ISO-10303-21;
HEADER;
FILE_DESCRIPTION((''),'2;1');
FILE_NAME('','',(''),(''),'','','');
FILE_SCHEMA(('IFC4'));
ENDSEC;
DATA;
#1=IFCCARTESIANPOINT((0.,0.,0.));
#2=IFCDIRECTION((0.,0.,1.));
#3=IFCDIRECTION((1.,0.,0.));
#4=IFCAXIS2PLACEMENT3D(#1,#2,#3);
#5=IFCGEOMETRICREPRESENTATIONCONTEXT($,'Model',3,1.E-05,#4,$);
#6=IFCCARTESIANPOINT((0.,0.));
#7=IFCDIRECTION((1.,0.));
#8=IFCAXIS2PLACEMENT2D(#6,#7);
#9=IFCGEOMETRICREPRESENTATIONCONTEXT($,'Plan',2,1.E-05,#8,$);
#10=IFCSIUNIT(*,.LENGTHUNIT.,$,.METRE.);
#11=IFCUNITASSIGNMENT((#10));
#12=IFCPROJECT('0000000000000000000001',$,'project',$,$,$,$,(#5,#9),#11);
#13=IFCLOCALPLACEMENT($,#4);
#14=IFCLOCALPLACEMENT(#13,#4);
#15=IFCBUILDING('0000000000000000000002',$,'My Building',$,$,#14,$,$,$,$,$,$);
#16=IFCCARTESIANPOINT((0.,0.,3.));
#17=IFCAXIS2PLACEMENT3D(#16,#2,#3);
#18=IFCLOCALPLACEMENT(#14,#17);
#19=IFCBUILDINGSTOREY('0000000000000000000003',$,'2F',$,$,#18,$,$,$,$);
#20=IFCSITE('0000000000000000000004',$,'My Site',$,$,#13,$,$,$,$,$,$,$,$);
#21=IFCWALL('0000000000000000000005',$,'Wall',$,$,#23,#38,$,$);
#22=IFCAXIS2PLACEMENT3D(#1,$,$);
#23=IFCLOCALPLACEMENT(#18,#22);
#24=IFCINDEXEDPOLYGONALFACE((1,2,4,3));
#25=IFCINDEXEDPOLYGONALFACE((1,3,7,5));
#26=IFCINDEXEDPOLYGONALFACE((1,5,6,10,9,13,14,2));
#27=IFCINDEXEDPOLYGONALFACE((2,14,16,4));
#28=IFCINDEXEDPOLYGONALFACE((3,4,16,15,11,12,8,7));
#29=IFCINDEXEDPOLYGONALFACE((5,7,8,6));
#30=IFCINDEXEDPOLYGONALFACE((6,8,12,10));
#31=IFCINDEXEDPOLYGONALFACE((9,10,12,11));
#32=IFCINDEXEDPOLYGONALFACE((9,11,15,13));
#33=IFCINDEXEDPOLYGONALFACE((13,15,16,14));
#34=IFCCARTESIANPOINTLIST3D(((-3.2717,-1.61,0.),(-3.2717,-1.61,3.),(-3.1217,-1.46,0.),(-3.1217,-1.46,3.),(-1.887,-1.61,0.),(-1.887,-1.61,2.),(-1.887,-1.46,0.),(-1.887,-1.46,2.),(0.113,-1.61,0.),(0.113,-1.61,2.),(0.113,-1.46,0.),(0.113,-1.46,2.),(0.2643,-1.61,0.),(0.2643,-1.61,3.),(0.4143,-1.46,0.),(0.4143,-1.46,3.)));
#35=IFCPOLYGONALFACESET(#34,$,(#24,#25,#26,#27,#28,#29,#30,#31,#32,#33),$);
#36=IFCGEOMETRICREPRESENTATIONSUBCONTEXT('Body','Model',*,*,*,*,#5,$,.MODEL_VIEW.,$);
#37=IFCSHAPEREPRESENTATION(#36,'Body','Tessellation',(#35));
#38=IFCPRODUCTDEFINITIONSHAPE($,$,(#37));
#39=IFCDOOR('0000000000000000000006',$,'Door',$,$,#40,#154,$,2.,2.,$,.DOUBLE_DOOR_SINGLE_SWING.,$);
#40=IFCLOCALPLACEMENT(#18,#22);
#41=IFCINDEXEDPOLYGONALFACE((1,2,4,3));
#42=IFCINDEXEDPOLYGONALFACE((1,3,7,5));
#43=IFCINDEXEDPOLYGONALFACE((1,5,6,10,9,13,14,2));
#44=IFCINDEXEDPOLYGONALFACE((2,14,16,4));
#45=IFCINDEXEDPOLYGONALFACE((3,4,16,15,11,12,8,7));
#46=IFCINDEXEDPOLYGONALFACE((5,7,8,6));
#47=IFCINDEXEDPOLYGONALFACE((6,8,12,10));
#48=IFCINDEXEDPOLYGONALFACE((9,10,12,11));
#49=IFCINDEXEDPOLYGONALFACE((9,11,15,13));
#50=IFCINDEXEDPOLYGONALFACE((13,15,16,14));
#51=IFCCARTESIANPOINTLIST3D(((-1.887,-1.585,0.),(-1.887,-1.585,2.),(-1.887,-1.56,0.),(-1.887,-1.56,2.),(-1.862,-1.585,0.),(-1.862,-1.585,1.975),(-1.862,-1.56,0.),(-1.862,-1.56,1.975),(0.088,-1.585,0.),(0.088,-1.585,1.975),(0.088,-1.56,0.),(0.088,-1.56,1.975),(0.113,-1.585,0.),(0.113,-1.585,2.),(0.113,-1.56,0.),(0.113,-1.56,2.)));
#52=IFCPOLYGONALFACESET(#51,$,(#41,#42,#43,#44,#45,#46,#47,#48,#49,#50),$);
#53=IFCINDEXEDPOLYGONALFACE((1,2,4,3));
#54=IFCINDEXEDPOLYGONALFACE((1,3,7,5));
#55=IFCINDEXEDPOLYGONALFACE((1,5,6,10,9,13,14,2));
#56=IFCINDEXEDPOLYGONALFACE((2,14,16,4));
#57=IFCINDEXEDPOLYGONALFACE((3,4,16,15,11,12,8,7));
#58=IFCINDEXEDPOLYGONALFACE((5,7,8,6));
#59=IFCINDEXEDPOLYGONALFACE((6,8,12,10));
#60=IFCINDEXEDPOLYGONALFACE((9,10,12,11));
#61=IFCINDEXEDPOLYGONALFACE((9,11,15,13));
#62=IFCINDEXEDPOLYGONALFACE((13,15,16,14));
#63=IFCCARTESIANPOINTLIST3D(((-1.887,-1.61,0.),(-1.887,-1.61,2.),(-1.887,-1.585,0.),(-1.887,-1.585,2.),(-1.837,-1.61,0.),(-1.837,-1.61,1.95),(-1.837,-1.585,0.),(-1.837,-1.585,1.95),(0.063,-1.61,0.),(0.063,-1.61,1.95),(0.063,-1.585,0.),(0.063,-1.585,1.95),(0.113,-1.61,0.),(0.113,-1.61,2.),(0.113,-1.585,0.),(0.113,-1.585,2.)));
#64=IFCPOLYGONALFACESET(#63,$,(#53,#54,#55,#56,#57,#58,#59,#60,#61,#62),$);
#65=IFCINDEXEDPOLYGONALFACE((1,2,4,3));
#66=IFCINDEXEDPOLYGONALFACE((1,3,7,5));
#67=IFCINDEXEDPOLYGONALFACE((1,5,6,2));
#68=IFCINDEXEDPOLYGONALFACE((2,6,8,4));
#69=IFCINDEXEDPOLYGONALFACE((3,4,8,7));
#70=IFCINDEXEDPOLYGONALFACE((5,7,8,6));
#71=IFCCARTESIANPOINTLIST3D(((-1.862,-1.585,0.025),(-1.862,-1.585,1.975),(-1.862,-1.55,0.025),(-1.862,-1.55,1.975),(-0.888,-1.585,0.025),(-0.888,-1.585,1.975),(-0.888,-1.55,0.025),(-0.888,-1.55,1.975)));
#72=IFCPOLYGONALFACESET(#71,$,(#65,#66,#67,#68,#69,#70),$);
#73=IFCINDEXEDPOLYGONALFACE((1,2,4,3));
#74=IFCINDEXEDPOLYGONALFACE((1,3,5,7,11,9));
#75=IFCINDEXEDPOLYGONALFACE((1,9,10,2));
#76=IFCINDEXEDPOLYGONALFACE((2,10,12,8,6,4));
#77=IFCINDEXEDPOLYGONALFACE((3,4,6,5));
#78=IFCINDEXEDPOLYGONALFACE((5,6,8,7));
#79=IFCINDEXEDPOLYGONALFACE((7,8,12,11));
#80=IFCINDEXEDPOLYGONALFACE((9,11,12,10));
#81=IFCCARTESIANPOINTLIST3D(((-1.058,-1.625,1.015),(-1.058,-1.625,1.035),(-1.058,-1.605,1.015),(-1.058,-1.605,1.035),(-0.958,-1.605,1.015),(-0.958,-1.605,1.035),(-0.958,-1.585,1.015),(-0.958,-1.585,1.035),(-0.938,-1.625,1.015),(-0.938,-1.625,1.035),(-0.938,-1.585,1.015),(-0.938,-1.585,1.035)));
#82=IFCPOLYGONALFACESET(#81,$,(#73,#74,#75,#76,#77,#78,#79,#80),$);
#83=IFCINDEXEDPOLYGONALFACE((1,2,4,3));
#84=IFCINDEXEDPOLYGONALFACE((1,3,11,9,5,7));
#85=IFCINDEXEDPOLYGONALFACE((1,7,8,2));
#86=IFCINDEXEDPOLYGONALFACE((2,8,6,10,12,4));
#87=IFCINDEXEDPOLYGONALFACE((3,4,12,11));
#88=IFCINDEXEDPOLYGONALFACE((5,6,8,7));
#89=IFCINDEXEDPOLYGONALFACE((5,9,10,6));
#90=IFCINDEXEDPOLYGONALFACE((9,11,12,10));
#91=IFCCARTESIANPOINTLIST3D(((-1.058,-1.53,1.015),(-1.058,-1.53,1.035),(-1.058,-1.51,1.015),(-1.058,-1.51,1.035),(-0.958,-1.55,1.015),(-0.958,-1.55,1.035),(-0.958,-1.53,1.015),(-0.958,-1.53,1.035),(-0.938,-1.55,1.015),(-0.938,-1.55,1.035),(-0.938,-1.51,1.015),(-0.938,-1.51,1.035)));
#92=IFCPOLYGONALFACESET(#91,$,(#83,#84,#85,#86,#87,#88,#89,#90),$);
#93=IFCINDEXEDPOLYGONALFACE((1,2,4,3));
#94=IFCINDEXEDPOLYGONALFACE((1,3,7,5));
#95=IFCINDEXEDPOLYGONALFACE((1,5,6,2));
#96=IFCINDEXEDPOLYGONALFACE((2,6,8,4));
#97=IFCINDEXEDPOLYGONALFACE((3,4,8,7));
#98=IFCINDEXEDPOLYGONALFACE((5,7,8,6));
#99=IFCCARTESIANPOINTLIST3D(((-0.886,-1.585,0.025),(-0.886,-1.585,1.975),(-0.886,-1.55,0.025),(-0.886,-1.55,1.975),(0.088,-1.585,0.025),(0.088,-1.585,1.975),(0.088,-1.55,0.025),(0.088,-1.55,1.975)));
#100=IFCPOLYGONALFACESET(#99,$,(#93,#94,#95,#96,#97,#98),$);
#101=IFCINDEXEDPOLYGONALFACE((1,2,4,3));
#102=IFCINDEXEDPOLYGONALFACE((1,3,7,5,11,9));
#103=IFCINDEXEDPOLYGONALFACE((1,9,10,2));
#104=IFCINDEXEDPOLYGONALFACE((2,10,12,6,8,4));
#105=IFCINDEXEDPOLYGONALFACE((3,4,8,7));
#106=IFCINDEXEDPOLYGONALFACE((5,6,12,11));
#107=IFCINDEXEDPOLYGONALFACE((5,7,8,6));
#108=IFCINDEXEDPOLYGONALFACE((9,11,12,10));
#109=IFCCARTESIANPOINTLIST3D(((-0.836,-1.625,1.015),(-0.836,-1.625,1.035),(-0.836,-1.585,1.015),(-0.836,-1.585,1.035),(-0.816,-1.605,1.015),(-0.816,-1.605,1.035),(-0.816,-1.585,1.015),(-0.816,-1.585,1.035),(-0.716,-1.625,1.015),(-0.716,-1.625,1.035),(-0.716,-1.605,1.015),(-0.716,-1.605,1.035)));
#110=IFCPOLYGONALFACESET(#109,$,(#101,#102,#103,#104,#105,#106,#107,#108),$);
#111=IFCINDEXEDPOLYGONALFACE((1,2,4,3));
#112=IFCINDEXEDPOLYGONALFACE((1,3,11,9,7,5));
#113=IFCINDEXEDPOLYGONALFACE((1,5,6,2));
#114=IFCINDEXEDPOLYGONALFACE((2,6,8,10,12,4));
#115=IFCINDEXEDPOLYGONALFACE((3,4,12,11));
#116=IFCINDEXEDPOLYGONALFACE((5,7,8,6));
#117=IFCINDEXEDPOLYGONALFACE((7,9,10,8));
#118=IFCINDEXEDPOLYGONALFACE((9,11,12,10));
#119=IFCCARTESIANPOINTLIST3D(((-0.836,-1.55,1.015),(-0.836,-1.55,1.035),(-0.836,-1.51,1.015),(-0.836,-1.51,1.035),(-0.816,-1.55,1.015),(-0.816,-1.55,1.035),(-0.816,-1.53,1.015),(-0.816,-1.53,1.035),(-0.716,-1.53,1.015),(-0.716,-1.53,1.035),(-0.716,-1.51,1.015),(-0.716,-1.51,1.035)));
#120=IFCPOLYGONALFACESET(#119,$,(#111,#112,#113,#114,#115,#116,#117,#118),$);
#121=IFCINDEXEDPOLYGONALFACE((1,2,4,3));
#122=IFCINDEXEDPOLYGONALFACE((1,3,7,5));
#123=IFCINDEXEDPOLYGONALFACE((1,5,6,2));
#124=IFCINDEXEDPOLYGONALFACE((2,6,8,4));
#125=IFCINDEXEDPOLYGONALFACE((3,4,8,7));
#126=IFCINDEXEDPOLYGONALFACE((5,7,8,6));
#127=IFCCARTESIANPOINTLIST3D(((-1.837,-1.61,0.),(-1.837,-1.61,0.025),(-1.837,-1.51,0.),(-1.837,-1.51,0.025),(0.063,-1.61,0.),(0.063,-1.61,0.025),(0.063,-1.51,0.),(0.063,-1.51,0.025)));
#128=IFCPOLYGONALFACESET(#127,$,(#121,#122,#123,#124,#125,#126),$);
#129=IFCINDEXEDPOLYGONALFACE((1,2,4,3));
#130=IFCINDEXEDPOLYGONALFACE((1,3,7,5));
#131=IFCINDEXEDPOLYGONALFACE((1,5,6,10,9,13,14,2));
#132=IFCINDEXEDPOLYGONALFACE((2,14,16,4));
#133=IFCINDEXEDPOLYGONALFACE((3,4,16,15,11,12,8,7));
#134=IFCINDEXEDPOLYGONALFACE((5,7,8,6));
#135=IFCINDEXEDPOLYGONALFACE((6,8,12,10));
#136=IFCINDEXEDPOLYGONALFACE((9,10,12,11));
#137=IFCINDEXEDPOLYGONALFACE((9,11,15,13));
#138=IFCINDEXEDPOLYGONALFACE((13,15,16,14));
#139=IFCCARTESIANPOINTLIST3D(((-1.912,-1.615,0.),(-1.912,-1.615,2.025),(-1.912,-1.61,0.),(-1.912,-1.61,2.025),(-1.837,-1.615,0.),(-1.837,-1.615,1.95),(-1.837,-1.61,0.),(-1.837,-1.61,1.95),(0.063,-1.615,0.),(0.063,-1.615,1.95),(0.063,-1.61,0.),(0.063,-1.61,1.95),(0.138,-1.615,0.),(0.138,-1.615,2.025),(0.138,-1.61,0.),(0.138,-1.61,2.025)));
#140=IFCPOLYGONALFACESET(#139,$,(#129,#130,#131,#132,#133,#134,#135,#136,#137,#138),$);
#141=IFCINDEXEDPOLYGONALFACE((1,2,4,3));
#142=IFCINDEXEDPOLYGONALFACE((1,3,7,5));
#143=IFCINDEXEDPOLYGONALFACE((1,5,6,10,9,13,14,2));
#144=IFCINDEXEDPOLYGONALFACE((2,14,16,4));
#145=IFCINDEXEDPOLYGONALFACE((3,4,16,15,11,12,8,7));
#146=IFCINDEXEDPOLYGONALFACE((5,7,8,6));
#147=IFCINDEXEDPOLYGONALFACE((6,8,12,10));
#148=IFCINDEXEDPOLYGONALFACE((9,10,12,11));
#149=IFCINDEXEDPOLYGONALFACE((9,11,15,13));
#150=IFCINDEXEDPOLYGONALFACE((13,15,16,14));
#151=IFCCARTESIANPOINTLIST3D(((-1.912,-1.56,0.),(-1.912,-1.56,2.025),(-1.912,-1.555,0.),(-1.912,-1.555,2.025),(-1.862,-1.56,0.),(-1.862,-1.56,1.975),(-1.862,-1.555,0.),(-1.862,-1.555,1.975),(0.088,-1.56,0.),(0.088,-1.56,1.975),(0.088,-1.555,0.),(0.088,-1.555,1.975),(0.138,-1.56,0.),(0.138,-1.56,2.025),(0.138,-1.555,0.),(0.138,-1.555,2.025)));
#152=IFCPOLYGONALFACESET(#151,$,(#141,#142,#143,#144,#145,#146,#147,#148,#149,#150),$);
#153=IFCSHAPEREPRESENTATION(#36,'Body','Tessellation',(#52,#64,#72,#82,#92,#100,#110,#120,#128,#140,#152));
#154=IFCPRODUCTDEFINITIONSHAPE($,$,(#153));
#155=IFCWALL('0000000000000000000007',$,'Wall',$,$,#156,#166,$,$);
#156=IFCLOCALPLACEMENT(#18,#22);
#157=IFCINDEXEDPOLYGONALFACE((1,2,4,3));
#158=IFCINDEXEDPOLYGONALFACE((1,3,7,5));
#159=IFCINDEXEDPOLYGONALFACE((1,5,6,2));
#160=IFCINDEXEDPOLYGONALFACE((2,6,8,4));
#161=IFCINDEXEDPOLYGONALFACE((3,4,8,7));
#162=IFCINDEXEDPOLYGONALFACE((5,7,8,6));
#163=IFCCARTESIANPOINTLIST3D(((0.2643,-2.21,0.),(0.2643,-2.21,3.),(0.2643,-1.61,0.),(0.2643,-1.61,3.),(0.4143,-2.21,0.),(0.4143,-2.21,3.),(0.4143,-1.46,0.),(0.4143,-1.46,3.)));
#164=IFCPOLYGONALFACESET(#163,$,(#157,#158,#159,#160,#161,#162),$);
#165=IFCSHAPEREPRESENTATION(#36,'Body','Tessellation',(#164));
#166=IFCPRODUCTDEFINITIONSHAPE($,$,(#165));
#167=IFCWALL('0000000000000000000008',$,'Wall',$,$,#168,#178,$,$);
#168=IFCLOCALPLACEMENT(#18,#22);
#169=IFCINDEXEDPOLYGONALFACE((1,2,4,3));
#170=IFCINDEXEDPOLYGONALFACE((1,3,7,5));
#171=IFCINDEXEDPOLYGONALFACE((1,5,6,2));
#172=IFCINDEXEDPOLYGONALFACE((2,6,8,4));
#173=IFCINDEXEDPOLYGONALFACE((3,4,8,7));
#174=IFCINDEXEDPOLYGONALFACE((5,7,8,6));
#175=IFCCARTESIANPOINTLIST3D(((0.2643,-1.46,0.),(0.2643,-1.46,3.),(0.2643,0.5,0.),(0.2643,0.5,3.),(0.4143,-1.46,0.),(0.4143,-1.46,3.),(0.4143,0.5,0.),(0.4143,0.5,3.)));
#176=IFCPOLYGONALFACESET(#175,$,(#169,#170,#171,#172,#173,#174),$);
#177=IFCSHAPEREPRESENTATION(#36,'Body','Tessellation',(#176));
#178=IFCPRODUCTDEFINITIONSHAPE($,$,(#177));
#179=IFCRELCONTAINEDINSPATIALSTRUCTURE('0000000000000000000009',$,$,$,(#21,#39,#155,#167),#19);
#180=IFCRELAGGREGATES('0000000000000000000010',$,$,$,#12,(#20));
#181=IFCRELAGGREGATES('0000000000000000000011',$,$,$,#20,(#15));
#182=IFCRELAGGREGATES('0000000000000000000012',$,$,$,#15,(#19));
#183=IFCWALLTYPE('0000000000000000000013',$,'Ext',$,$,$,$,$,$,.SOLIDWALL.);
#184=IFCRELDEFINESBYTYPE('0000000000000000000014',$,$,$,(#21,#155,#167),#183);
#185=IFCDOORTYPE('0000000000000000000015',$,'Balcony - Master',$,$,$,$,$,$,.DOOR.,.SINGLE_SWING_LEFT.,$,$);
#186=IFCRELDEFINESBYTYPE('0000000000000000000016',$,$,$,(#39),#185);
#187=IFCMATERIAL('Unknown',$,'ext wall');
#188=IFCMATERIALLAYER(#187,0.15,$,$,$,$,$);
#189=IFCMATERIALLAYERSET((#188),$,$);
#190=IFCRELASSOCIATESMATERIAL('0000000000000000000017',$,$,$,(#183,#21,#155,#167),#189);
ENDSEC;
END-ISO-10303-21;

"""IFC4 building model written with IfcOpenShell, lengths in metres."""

from ifc_helpers import new_model, entity, si_unit, frame, origin_with_axes, origin_2d_with_axis, place, context, subcontext, project, spatial, line, indexed_curve, outline, extrude, shape, source, transform, mapped, material, layer, layer_set, layer_usage, type_object, type_shapes, element, fill, save


model = new_model("IFC4")

# Units and contexts
model_context = context("Model", 3, precision=1e-05, world=origin_with_axes())
plan_context = context("Plan", 2, precision=1e-05, world=origin_2d_with_axis())
body_context_1 = subcontext(model_context, "Body", "Model", "MODEL_VIEW")
body_context_2 = subcontext(plan_context, "Body", "Plan", "PLAN_VIEW")
ifc_project = project(units=[si_unit("LENGTHUNIT", "METRE")], contexts=[model_context, plan_context])

# Site, building, storey
site_placement = place(None, origin_with_axes())
site = spatial("IfcSite", under=ifc_project, at=site_placement, Name="My Site")
building_placement = place(site_placement, origin_with_axes())
building = spatial("IfcBuilding", under=site, at=building_placement, Name="My Building")
storey_placement = place(building_placement, frame((0.0, 0.0, 3.0), z_axis=(0.0, 0.0, 1.0), x_axis=(1.0, 0.0, 0.0)))
storey = spatial("IfcBuildingStorey", under=building, at=storey_placement, Name="2F")

# Shared definitions
ifc_material = material(Name="Unknown", Category="ext wall")

# Shared definitions
ifc_layer_1 = layer(ifc_material, 0.15)
ifc_layer_set_1 = layer_set([ifc_layer_1])
wall_type_1 = type_object("IfcWallType", Name="Ext", PredefinedType="SOLIDWALL", material=ifc_layer_set_1)

# Wall, opening, door
ifc_layer_usage_1 = layer_usage(ifc_layer_set_1, "AXIS2", "POSITIVE", 0.0)
wall_1_placement = place(storey_placement, frame((-3.2717, -1.61, 0.0), z_axis=(0.0, 0.0, 1.0), x_axis=(1.0, 0.0, 0.0)))
wall_1 = element("IfcWall", 1, at=wall_1_placement, inside=storey, type_object=wall_type_1, material=ifc_layer_usage_1, Name="Wall", context=body_context_1, shape_type="SweptSolid", body=[
    extrude(outline(indexed_curve([(0.0, 0.0), (0.15, 0.15), (3.686, 0.15), (3.536, 0.0)], segments=[line(1, 2, 3, 4, 1)])), origin_with_axes(), (0.0, 0.0, 1.0), 3.0),
])
shared_shape_1 = source(origin_with_axes(), body_context_1, "Body", "SweptSolid", [
    extrude(outline(indexed_curve([(0.0, 0.0), (2.0, 0.0), (2.0, 2.0), (0.0, 2.0)], segments=[line(1, 2, 3, 4, 1)])), frame((0.0, -0.6, 0.0), z_axis=(0.0, -1.0, 0.0), x_axis=(1.0, 0.0, 0.0)), (0.0, 0.0, -1.0), 1.2),
])
opening_1_placement = place(wall_1_placement, frame((1.3847, 0.0, 0.0), z_axis=(0.0, 0.0, 1.0), x_axis=(1.0, 0.0, 0.0)))
opening_1 = element("IfcOpeningElement", 2, at=opening_1_placement, cuts=wall_1, PredefinedType="OPENING", context=body_context_1, shape_type="MappedRepresentation", body=[
    mapped(shared_shape_1, transform((0.0, 0.0, 0.0), x_axis=(1.0, 0.0, 0.0), y_axis=(0.0, 1.0, 0.0), z_axis=(0.0, 0.0, 1.0), scale=1.0)),
])
door_type_1 = type_object("IfcDoorType", Name="Balcony - Master", OperationType="SINGLE_SWING_LEFT", PredefinedType="DOOR")
shared_shape_2 = source(origin_with_axes(), body_context_1, "Body", "SweptSolid", [
    extrude(outline(indexed_curve([(0.0, 0.0), (0.0, 2.0), (2.0, 2.0), (2.0, 0.0), (1.975, 0.0), (1.975, 1.975), (0.025, 1.975), (0.025, 0.0)], segments=[line(1, 2, 3, 4, 5, 6, 7, 8, 1)])), frame((0.0, 0.025, 0.0), z_axis=(0.0, -1.0, 0.0), x_axis=(1.0, 0.0, 0.0)), (0.0, 0.0, -1.0), 0.025),
    extrude(outline(indexed_curve([(0.0, 0.0), (0.0, 2.0), (2.0, 2.0), (2.0, 0.0), (1.95, 0.0), (1.95, 1.95), (0.05, 1.95), (0.05, 0.0)], segments=[line(1, 2, 3, 4, 5, 6, 7, 8, 1)])), frame((0.0, 0.0, 0.0), z_axis=(0.0, -1.0, 0.0), x_axis=(1.0, 0.0, 0.0)), (0.0, 0.0, -1.0), 0.025),
    extrude(outline(indexed_curve([(0.0, 0.0), (0.974, 0.0), (0.974, 0.035), (0.0, 0.035)], segments=[line(1, 2, 3, 4, 1)])), frame((0.025, 0.025, 0.025), z_axis=(0.0, 0.0, 1.0), x_axis=(1.0, 0.0, 0.0)), (0.0, 0.0, 1.0), 1.95),
    extrude(outline(indexed_curve([(0.0, 0.0), (0.0, -0.04), (-0.12, -0.04), (-0.12, -0.02), (-0.02, -0.02), (-0.02, 0.0)], segments=[line(1, 2, 3, 4, 5, 6, 1)])), frame((0.949, 0.025, 1.015), z_axis=(0.0, 0.0, 1.0), x_axis=(1.0, 0.0, 0.0)), (0.0, 0.0, 1.0), 0.02),
    extrude(outline(indexed_curve([(0.0, 0.0), (0.0, 0.04), (-0.12, 0.04), (-0.12, 0.02), (-0.02, 0.02), (-0.02, 0.0)], segments=[line(1, 2, 3, 4, 5, 6, 1)])), frame((0.949, 0.06, 1.015), z_axis=(0.0, 0.0, 1.0), x_axis=(1.0, 0.0, 0.0)), (0.0, 0.0, 1.0), 0.02),
    extrude(outline(indexed_curve([(0.0, 0.0), (-0.974, 0.0), (-0.974, 0.035), (0.0, 0.035)], segments=[line(1, 2, 3, 4, 1)])), frame((1.975, 0.025, 0.025), z_axis=(0.0, 0.0, 1.0), x_axis=(1.0, 0.0, 0.0)), (0.0, 0.0, 1.0), 1.95),
    extrude(outline(indexed_curve([(0.0, 0.0), (0.0, -0.04), (0.12, -0.04), (0.12, -0.02), (0.02, -0.02), (0.02, 0.0)], segments=[line(1, 2, 3, 4, 5, 6, 1)])), frame((1.051, 0.025, 1.015), z_axis=(0.0, 0.0, 1.0), x_axis=(1.0, 0.0, 0.0)), (0.0, 0.0, 1.0), 0.02),
    extrude(outline(indexed_curve([(0.0, 0.0), (0.0, 0.04), (0.12, 0.04), (0.12, 0.02), (0.02, 0.02), (0.02, 0.0)], segments=[line(1, 2, 3, 4, 5, 6, 1)])), frame((1.051, 0.06, 1.015), z_axis=(0.0, 0.0, 1.0), x_axis=(1.0, 0.0, 0.0)), (0.0, 0.0, 1.0), 0.02),
    extrude(outline(indexed_curve([(0.0, 0.0), (1.9, 0.0), (1.9, 0.1), (0.0, 0.1)], segments=[line(1, 2, 3, 4, 1)])), frame((0.05, 0.0, 0.0), z_axis=(0.0, 0.0, 1.0), x_axis=(1.0, 0.0, 0.0)), (0.0, 0.0, 1.0), 0.025),
    extrude(outline(indexed_curve([(0.0, 0.0), (0.0, 2.025), (2.05, 2.025), (2.05, 0.0), (1.975, 0.0), (1.975, 1.95), (0.075, 1.95), (0.075, 0.0)], segments=[line(1, 2, 3, 4, 5, 6, 7, 8, 1)])), frame((-0.025, -0.005, 0.0), z_axis=(0.0, -1.0, 0.0), x_axis=(1.0, 0.0, 0.0)), (0.0, 0.0, -1.0), 0.005),
    extrude(outline(indexed_curve([(0.0, 0.0), (0.0, 2.025), (2.05, 2.025), (2.05, 0.0), (2.0, 0.0), (2.0, 1.975), (0.05, 1.975), (0.05, 0.0)], segments=[line(1, 2, 3, 4, 5, 6, 7, 8, 1)])), frame((-0.025, 0.05, 0.0), z_axis=(0.0, -1.0, 0.0), x_axis=(1.0, 0.0, 0.0)), (0.0, 0.0, -1.0), 0.005),
])
shared_shape_3 = source(origin_with_axes(), body_context_2, "Body", "Curve2D", [
    entity("IfcIndexedPolyCurve", entity("IfcCartesianPointList2D", [[0.0, 0.0], [0.0, 0.05], [0.025, 0.05], [0.025, 0.025], [0.05, 0.025], [0.05, 0.0]]), [entity("IfcLineIndex", [1, 2, 3, 4, 5, 6, 1])]),
    entity("IfcIndexedPolyCurve", entity("IfcCartesianPointList2D", [[2.0, 0.0], [2.0, 0.05], [1.975, 0.05], [1.975, 0.025], [1.95, 0.025], [1.95, 0.0]]), [entity("IfcLineIndex", [1, 2, 3, 4, 5, 6, 1])]),
    entity("IfcTrimmedCurve", entity("IfcEllipse", entity("IfcAxis2Placement2D", entity("IfcCartesianPoint", [0.06, 0.05]), entity("IfcDirection", [1.0, 0.0])), 0.94, 0.975), [entity("IfcCartesianPoint", [1.0, 0.05])], [entity("IfcCartesianPoint", [0.06, 1.025])], True, "CARTESIAN"),
    entity("IfcIndexedPolyCurve", entity("IfcCartesianPointList2D", [[0.025, 0.05], [0.06, 0.05], [0.06, 1.025], [0.025, 1.025]]), [entity("IfcLineIndex", [1, 2, 3, 4, 1])]),
    entity("IfcTrimmedCurve", entity("IfcEllipse", entity("IfcAxis2Placement2D", entity("IfcCartesianPoint", [1.94, 0.05]), entity("IfcDirection", [1.0, 0.0])), 0.94, 0.975), [entity("IfcCartesianPoint", [1.94, 1.025])], [entity("IfcCartesianPoint", [1.0, 0.05])], True, "CARTESIAN"),
    entity("IfcIndexedPolyCurve", entity("IfcCartesianPointList2D", [[1.975, 0.05], [1.94, 0.05], [1.94, 1.025], [1.975, 1.025]]), [entity("IfcLineIndex", [1, 2, 3, 4, 1])]),
])
type_shapes(door_type_1, [shared_shape_2, shared_shape_3])
door_1_placement = place(opening_1_placement, frame((0.0, 0.0, 0.0), z_axis=(0.0, 0.0, 1.0), x_axis=(1.0, 0.0, 0.0)))
door_1 = element("IfcDoor", 3, at=door_1_placement, inside=storey, type_object=door_type_1, Name="Door", OperationType="DOUBLE_DOOR_SINGLE_SWING", OverallHeight=2.0, OverallWidth=2.0, shapes=[
    shape(body_context_1, "Body", "MappedRepresentation", [mapped(shared_shape_2, transform((0.0, 0.0, 0.0), x_axis=(1.0, 0.0, 0.0), y_axis=(0.0, 1.0, 0.0), z_axis=(0.0, 0.0, 1.0), scale=1.0))]),
    shape(body_context_2, "Body", "MappedRepresentation", [mapped(shared_shape_3, transform((0.0, 0.0, 0.0), x_axis=(1.0, 0.0, 0.0), y_axis=(0.0, 1.0, 0.0), z_axis=(0.0, 0.0, 1.0), scale=1.0))]),
])
fill(opening_1, door_1)

# Walls
ifc_layer_usage_2 = layer_usage(ifc_layer_set_1, "AXIS2", "POSITIVE", 0.0)
wall_2_placement = place(storey_placement, frame((0.2643, -1.61, 0.0), z_axis=(0.0, 0.0, 1.0), x_axis=(0.0, -1.0, 0.0)))
element("IfcWall", 4, at=wall_2_placement, inside=storey, type_object=wall_type_1, material=ifc_layer_usage_2, Name="Wall", context=body_context_1, shape_type="SweptSolid", body=[
    extrude(outline(indexed_curve([(0.0, 0.0), (-0.15, 0.15), (0.6, 0.15), (0.6, 0.0)], segments=[line(1, 2, 3, 4, 1)])), origin_with_axes(), (0.0, 0.0, 1.0), 3.0),
])
ifc_layer_usage_3 = layer_usage(ifc_layer_set_1, "AXIS2", "POSITIVE", 0.0)
wall_3_placement = place(storey_placement, frame((0.4143, -1.46, 0.0), z_axis=(0.0, 0.0, 1.0), x_axis=(0.0, 1.0, 0.0)))
element("IfcWall", 5, at=wall_3_placement, inside=storey, type_object=wall_type_1, material=ifc_layer_usage_3, Name="Wall", context=body_context_1, shape_type="SweptSolid", body=[
    extrude(outline(indexed_curve([(0.0, 0.0), (0.0, 0.15), (1.96, 0.15), (1.96, 0.0)], segments=[line(1, 2, 3, 4, 1)])), origin_with_axes(), (0.0, 0.0, 1.0), 3.0),
])

save(model, "model.ifc")
